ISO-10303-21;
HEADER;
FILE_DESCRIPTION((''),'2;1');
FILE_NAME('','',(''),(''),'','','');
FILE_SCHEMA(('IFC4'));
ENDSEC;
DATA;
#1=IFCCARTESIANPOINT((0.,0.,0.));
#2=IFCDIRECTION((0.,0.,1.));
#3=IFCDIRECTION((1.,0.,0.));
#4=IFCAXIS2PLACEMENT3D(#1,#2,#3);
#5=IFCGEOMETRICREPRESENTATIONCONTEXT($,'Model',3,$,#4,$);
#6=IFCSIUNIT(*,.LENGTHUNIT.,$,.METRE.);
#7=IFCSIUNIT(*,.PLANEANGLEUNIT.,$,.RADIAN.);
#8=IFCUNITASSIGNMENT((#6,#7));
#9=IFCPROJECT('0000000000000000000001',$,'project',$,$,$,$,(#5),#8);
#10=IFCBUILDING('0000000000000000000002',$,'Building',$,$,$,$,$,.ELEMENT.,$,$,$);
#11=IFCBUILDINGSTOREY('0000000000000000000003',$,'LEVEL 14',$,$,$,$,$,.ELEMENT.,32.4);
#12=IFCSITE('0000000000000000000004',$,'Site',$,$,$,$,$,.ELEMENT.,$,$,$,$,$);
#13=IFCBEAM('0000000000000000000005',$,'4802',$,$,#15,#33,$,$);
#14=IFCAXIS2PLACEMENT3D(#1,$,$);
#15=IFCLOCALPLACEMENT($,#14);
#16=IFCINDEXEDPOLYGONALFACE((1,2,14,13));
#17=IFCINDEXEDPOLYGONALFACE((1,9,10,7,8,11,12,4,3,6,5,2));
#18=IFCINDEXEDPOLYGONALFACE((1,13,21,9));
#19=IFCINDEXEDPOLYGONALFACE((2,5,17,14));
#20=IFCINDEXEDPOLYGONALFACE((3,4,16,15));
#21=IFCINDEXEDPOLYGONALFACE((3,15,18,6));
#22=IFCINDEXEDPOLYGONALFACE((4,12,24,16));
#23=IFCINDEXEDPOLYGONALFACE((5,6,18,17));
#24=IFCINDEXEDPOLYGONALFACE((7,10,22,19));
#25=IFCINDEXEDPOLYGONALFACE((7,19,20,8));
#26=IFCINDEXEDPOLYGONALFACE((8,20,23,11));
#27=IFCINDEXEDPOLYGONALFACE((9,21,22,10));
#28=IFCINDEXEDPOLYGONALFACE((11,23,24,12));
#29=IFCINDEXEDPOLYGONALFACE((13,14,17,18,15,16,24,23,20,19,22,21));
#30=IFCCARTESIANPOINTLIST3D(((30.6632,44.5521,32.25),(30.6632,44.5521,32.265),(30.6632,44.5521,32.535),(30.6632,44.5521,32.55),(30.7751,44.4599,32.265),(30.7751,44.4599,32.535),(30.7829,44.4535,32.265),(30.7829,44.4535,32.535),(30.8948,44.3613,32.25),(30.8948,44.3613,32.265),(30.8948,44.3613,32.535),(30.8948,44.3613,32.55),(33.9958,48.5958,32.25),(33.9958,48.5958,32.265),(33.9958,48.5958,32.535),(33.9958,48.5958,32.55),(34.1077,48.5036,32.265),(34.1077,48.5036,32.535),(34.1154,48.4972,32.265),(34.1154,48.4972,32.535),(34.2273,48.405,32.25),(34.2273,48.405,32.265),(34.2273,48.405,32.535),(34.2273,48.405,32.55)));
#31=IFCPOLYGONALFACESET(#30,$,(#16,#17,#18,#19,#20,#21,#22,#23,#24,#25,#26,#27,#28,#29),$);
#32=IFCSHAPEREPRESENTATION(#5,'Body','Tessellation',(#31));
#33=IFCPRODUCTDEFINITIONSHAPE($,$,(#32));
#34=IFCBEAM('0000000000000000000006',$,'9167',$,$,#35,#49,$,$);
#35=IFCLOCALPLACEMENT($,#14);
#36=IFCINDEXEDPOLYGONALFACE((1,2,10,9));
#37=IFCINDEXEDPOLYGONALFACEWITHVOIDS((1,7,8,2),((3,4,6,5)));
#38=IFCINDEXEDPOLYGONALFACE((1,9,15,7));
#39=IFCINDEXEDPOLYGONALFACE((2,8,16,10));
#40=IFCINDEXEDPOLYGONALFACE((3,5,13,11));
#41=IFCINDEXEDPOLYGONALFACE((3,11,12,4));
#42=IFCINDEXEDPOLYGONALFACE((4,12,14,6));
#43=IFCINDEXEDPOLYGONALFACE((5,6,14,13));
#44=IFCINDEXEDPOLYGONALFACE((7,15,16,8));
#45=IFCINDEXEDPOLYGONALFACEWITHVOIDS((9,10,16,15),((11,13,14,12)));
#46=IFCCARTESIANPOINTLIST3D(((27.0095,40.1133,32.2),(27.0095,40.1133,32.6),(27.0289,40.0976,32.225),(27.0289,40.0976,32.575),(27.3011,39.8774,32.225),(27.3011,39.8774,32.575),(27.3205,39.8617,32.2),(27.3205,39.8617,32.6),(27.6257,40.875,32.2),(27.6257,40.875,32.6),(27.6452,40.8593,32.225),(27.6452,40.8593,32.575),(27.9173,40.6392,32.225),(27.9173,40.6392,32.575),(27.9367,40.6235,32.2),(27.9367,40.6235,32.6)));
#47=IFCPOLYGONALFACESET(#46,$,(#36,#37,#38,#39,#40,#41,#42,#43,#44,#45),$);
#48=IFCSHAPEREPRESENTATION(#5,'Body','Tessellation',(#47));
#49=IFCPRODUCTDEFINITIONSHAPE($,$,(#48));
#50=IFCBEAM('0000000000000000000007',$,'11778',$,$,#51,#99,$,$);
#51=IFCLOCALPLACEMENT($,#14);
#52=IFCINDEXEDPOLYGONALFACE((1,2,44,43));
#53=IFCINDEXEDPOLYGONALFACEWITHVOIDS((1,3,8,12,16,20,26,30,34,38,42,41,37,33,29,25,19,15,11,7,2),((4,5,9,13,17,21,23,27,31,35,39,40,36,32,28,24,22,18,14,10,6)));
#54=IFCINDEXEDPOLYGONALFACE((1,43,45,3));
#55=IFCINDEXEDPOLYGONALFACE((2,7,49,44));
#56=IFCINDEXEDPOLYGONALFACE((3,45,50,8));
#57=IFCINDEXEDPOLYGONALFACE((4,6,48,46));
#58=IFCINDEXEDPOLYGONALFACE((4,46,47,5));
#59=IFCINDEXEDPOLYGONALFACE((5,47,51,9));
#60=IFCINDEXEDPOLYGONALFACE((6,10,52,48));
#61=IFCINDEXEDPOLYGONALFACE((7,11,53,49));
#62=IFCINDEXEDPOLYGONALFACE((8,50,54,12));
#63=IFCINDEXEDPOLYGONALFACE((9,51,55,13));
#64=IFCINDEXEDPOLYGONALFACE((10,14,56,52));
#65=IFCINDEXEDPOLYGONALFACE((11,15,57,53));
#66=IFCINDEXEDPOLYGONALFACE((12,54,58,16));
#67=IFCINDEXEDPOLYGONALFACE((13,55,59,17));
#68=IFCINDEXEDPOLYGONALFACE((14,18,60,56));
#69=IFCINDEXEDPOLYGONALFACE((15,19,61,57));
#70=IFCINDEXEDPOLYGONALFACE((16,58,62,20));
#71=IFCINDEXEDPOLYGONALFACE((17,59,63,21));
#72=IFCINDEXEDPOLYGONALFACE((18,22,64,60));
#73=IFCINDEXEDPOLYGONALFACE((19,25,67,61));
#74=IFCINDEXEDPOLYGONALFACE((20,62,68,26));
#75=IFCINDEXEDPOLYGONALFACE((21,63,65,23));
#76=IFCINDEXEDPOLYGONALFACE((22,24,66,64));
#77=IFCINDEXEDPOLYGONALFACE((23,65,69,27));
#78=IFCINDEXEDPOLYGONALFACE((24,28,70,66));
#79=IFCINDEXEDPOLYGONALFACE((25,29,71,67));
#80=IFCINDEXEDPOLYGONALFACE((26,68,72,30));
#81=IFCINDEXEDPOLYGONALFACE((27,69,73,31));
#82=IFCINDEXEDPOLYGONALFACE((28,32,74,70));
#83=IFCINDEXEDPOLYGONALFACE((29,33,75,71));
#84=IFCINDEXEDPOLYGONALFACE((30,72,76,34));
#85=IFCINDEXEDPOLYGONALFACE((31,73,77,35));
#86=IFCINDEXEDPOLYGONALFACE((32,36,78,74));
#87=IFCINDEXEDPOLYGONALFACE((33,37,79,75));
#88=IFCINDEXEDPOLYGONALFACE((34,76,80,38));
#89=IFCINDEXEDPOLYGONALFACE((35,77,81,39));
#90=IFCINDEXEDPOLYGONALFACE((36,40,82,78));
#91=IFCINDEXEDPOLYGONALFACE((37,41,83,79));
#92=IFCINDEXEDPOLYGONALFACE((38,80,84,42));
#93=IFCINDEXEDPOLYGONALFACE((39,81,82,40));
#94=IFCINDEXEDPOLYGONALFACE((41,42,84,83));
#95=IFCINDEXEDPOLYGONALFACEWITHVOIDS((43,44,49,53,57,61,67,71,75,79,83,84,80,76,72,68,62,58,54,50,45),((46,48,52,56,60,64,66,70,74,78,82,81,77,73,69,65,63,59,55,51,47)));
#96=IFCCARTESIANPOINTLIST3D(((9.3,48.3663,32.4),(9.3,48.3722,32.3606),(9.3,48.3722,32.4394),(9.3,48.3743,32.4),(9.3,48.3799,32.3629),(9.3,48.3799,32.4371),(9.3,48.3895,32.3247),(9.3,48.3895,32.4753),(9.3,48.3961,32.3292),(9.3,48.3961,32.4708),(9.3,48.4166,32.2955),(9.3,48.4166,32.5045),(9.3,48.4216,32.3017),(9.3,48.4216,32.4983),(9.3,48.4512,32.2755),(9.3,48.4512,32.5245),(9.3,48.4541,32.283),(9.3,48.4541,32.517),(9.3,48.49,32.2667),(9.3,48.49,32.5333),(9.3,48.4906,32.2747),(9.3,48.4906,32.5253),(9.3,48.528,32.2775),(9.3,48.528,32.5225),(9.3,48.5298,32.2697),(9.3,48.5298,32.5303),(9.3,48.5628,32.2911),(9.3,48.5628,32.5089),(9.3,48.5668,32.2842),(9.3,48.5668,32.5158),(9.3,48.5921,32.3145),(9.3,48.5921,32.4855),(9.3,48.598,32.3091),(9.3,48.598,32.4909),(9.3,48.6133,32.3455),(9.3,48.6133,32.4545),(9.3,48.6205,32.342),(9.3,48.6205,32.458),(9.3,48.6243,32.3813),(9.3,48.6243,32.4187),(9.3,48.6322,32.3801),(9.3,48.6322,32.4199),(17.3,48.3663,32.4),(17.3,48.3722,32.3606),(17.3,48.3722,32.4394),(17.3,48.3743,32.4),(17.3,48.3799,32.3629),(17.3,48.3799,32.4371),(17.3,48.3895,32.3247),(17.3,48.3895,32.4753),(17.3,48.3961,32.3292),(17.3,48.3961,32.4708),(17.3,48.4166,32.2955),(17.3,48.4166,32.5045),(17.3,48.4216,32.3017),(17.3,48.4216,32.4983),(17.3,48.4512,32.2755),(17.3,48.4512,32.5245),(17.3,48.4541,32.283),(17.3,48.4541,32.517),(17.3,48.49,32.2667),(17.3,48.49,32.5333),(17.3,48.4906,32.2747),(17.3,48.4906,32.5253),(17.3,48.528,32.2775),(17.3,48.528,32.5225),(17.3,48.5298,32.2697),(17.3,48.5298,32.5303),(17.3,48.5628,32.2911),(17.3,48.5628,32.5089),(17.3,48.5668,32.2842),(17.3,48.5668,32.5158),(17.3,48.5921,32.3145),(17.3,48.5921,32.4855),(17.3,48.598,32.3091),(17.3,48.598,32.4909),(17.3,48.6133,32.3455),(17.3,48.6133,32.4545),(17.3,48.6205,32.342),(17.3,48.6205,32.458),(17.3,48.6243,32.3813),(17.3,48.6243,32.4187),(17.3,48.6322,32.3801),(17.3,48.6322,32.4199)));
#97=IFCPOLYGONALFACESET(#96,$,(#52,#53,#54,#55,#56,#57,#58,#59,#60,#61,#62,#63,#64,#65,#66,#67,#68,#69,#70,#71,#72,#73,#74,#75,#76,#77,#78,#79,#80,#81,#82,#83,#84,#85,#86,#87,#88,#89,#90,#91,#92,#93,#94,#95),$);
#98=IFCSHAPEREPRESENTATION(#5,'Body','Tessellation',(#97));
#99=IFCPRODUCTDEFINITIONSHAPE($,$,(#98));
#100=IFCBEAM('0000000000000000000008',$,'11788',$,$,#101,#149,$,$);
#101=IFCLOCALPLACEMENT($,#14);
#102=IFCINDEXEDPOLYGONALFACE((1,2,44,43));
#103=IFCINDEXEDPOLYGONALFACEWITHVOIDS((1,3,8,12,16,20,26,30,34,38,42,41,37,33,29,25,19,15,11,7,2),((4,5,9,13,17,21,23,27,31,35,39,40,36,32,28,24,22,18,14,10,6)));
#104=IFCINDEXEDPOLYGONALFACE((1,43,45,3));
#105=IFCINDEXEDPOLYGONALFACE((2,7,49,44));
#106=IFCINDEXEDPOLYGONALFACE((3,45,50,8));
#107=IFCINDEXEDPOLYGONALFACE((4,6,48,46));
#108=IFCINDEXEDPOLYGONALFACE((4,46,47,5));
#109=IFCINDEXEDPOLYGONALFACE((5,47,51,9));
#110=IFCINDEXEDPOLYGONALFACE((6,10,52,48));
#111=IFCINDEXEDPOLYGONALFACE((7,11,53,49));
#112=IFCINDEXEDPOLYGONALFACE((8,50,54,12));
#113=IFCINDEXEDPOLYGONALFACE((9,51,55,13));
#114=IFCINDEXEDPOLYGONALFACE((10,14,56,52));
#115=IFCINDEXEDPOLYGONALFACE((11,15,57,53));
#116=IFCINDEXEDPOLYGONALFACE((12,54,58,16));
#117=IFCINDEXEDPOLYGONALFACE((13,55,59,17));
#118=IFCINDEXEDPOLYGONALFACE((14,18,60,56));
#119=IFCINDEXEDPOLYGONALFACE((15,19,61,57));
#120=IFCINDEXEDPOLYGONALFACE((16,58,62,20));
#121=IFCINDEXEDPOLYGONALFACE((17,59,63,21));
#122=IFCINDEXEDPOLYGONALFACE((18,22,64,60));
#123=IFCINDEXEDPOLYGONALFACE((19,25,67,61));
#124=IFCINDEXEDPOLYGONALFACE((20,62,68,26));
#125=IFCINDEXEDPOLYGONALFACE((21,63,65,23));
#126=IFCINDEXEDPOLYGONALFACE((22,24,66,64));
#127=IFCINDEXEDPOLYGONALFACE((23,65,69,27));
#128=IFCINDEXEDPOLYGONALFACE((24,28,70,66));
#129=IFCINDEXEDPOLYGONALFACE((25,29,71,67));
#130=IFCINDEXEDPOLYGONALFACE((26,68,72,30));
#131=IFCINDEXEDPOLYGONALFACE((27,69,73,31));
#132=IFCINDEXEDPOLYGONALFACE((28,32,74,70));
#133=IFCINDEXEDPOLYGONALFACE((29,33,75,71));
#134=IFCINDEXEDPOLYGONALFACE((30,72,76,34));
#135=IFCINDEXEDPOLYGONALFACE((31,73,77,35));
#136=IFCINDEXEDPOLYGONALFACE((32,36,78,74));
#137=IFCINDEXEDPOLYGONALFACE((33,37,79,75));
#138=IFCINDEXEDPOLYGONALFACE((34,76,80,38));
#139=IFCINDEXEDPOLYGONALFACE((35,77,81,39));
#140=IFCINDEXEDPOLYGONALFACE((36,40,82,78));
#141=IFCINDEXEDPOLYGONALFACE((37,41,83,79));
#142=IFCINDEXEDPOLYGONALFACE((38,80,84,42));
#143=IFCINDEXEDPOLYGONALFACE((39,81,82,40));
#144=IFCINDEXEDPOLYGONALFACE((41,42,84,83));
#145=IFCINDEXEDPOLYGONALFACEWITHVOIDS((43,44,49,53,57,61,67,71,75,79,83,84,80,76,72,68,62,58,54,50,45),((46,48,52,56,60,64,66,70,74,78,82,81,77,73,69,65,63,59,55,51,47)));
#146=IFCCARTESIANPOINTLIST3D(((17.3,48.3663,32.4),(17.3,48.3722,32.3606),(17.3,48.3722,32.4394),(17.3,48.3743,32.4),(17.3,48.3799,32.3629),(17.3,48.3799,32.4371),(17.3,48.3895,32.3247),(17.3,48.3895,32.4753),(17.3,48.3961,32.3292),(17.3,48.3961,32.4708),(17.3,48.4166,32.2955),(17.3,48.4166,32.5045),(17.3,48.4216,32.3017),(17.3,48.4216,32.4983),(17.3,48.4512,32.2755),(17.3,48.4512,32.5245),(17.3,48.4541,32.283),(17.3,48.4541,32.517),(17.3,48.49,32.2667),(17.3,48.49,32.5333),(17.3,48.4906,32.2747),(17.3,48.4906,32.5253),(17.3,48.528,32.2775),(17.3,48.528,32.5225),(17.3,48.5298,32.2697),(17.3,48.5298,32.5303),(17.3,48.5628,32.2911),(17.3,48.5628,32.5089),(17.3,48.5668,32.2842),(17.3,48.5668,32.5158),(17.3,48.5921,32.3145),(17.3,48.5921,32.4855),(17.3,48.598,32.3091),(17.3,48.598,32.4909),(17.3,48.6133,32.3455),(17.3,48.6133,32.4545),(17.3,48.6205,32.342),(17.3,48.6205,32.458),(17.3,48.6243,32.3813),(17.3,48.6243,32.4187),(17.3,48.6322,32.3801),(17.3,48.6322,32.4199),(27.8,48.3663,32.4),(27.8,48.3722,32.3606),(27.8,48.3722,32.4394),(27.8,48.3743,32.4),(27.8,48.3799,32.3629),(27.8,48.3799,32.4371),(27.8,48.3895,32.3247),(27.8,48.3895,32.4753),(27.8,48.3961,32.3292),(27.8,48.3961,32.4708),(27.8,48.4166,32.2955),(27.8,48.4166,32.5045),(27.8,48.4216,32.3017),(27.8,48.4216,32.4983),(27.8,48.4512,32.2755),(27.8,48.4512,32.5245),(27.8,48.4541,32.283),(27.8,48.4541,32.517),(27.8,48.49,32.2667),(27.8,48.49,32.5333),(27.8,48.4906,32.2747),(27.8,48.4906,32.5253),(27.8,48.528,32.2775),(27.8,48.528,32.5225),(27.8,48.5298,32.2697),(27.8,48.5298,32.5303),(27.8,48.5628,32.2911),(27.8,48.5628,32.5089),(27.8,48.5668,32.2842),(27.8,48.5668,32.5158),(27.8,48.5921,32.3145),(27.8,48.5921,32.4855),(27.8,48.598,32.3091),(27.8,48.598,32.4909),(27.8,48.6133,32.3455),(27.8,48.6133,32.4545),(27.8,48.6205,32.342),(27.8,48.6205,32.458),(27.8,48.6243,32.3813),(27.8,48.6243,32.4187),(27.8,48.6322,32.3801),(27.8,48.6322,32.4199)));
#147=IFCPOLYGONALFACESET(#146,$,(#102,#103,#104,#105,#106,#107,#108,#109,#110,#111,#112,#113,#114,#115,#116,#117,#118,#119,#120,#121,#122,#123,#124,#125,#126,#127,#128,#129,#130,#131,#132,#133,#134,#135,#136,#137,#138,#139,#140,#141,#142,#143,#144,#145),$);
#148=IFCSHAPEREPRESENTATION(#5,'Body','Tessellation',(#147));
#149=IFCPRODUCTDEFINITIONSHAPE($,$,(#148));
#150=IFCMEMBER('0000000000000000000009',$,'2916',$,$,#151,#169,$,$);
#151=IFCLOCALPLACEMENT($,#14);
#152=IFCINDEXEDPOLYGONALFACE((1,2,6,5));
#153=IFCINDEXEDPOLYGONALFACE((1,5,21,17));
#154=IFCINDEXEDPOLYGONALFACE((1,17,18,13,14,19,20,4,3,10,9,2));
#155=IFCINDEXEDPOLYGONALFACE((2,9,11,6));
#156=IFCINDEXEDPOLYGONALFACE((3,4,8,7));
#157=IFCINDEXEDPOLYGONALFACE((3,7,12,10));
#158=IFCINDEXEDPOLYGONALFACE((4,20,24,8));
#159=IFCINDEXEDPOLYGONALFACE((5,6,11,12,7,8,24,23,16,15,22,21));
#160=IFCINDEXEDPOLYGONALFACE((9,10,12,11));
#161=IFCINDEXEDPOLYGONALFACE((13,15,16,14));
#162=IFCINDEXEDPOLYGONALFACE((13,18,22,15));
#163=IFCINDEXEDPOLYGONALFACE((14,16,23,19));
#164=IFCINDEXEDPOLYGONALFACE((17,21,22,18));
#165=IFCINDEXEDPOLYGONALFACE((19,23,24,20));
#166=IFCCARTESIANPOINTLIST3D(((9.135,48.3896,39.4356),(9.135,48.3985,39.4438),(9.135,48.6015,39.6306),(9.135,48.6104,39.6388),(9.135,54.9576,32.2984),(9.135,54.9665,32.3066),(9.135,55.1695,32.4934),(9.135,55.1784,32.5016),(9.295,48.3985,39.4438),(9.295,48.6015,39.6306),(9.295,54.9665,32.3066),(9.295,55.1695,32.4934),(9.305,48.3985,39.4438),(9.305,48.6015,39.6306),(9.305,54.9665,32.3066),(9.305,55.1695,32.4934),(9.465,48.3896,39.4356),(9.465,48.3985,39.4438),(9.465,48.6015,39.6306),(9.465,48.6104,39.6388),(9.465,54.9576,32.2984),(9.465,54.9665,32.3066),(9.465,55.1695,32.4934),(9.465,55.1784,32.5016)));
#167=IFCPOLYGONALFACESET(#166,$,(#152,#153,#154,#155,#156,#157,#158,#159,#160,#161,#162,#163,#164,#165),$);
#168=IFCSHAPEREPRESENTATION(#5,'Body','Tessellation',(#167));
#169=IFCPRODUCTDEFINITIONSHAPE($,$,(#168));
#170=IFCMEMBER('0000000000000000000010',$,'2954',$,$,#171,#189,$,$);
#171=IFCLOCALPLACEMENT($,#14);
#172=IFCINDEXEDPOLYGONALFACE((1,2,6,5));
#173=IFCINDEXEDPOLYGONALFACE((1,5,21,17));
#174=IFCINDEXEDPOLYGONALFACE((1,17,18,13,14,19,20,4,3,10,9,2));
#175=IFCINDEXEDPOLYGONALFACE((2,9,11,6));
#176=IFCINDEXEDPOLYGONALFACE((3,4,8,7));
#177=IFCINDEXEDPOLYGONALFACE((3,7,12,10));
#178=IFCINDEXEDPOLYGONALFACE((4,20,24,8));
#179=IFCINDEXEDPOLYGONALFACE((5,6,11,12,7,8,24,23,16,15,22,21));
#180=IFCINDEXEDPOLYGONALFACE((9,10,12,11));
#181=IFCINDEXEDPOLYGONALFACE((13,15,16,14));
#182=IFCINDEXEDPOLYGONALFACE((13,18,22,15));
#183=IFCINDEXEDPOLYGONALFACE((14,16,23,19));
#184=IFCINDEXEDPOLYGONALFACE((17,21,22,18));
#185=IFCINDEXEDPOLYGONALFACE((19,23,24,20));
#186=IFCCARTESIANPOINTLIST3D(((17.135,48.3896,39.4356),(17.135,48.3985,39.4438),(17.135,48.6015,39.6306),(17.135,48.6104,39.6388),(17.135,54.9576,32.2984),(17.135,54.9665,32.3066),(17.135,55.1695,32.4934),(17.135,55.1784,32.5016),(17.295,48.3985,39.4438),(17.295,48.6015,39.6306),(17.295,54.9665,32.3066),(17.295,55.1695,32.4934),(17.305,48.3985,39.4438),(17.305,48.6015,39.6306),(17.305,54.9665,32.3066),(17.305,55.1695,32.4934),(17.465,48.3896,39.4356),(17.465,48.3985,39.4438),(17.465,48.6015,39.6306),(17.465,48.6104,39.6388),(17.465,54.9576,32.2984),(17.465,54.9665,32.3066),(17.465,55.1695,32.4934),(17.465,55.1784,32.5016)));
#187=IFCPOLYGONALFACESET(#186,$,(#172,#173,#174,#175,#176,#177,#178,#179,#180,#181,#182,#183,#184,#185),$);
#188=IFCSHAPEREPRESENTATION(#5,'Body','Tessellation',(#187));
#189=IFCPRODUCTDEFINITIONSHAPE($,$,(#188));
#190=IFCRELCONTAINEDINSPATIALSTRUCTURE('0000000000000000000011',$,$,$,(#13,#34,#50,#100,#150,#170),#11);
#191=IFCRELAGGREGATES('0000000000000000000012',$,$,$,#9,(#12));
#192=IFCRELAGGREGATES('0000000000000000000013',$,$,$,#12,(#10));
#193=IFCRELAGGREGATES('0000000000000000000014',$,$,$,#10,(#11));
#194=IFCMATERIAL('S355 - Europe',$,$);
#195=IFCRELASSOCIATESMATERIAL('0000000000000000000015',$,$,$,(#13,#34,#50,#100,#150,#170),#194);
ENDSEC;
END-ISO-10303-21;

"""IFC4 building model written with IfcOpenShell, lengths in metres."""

from ifc_helpers import new_model, si_unit, frame, origin_with_axes, origin_2d_with_axis, place, context, project, spatial, hollow_rectangle, hollow_circle, i_section, extrude, material, material_profile, profile_set, profile_usage, element, save


model = new_model("IFC4")

# Units and contexts
model_context = context("Model", 3, world=origin_with_axes())
ifc_project = project(units=[si_unit("LENGTHUNIT", "METRE"), si_unit("PLANEANGLEUNIT", "RADIAN")], contexts=[model_context])

# Site, building, storey
site = spatial("IfcSite", under=ifc_project, Name="Site", CompositionType="ELEMENT")
building = spatial("IfcBuilding", under=site, Name="Building", CompositionType="ELEMENT")
storey = spatial("IfcBuildingStorey", under=building, Name="LEVEL 14", CompositionType="ELEMENT", Elevation=32.4)

# Shared definitions
ifc_material = material(Name="S355 - Europe")

# Beams
ifc_material_profile_1 = material_profile(ifc_material, i_section(OverallWidth=0.3, OverallDepth=0.3, WebThickness=0.01, FlangeThickness=0.015, at=origin_2d_with_axis()))
ifc_profile_set_1 = profile_set([ifc_material_profile_1])
ifc_profile_usage_1 = profile_usage(ifc_profile_set_1, cardinal=10)
beam_1_placement = place(None, frame((30.779, 44.4567, 32.4), z_axis=(0.635983, 0.771703, 0.0), x_axis=(-0.771703, 0.635983, 0.0)))
element("IfcBeam", 1, at=beam_1_placement, inside=storey, material=ifc_profile_usage_1, Name="4802", context=model_context, shape_type="SweptSolid", body=[
    extrude(i_section(OverallWidth=0.3, OverallDepth=0.3, WebThickness=0.01, FlangeThickness=0.015, at=origin_2d_with_axis()), origin_with_axes(), (0.0, 0.0, 1.0), 5.24),
])
ifc_material_profile_2 = material_profile(ifc_material, hollow_rectangle(XDim=0.4, YDim=0.4, WallThickness=0.025, at=origin_2d_with_axis()))
ifc_profile_set_2 = profile_set([ifc_material_profile_2])
ifc_profile_usage_2 = profile_usage(ifc_profile_set_2, cardinal=10)
beam_2_placement = place(None, frame((27.165, 39.9875, 32.4), z_axis=(0.62892, 0.77747, 0.0), x_axis=(-0.777826, 0.62848, 0.0)))
element("IfcBeam", 2, at=beam_2_placement, inside=storey, material=ifc_profile_usage_2, Name="9167", context=model_context, shape_type="SweptSolid", body=[
    extrude(hollow_rectangle(XDim=0.4, YDim=0.4, WallThickness=0.025, at=origin_2d_with_axis()), origin_with_axes(), (0.0, 0.0, 1.0), 0.9798),
])
ifc_material_profile_3 = material_profile(ifc_material, hollow_circle(Radius=0.1337, WallThickness=0.008, at=origin_2d_with_axis()))
ifc_profile_set_3 = profile_set([ifc_material_profile_3])
ifc_profile_usage_3 = profile_usage(ifc_profile_set_3, cardinal=10)
beam_3_placement = place(None, frame((17.3, 48.5, 32.4), z_axis=(-1.0, 0.0, 0.0), x_axis=(0.0, -1.0, 0.0)))
element("IfcBeam", 3, at=beam_3_placement, inside=storey, material=ifc_profile_usage_3, Name="11778", context=model_context, shape_type="SweptSolid", body=[
    extrude(hollow_circle(Radius=0.1337, WallThickness=0.008, at=origin_2d_with_axis()), origin_with_axes(), (0.0, 0.0, 1.0), 8.0),
])
ifc_material_profile_4 = material_profile(ifc_material, hollow_circle(Radius=0.1337, WallThickness=0.008, at=origin_2d_with_axis()))
ifc_profile_set_4 = profile_set([ifc_material_profile_4])
ifc_profile_usage_4 = profile_usage(ifc_profile_set_4, cardinal=10)
beam_4_placement = place(None, frame((27.8, 48.5, 32.4), z_axis=(-1.0, 0.0, 0.0), x_axis=(0.0, -1.0, 0.0)))
element("IfcBeam", 4, at=beam_4_placement, inside=storey, material=ifc_profile_usage_4, Name="11788", context=model_context, shape_type="SweptSolid", body=[
    extrude(hollow_circle(Radius=0.1337, WallThickness=0.008, at=origin_2d_with_axis()), origin_with_axes(), (0.0, 0.0, 1.0), 10.5),
])

# Members
ifc_material_profile_5 = material_profile(ifc_material, i_section(OverallWidth=0.33, OverallDepth=0.3, WebThickness=0.01, FlangeThickness=0.012, at=origin_2d_with_axis()))
ifc_profile_set_5 = profile_set([ifc_material_profile_5])
ifc_profile_usage_5 = profile_usage(ifc_profile_set_5, cardinal=10)
member_1_placement = place(None, frame((9.3, 55.068, 32.4), z_axis=(0.0, -0.677156, 0.73584), x_axis=(1.0, 0.0, 0.0)))
element("IfcMember", 5, at=member_1_placement, inside=storey, material=ifc_profile_usage_5, Name="2916", context=model_context, shape_type="SweptSolid", body=[
    extrude(i_section(OverallWidth=0.33, OverallDepth=0.3, WebThickness=0.01, FlangeThickness=0.012, at=origin_2d_with_axis()), origin_with_axes(), (0.0, 0.0, 1.0), 9.6994),
])
ifc_material_profile_6 = material_profile(ifc_material, i_section(OverallWidth=0.33, OverallDepth=0.3, WebThickness=0.01, FlangeThickness=0.012, at=origin_2d_with_axis()))
ifc_profile_set_6 = profile_set([ifc_material_profile_6])
ifc_profile_usage_6 = profile_usage(ifc_profile_set_6, cardinal=10)
member_2_placement = place(None, frame((17.3, 55.068, 32.4), z_axis=(0.0, -0.677156, 0.73584), x_axis=(1.0, 0.0, 0.0)))
element("IfcMember", 6, at=member_2_placement, inside=storey, material=ifc_profile_usage_6, Name="2954", context=model_context, shape_type="SweptSolid", body=[
    extrude(i_section(OverallWidth=0.33, OverallDepth=0.3, WebThickness=0.01, FlangeThickness=0.012, at=origin_2d_with_axis()), origin_with_axes(), (0.0, 0.0, 1.0), 9.6994),
])

save(model, "model.ifc")
